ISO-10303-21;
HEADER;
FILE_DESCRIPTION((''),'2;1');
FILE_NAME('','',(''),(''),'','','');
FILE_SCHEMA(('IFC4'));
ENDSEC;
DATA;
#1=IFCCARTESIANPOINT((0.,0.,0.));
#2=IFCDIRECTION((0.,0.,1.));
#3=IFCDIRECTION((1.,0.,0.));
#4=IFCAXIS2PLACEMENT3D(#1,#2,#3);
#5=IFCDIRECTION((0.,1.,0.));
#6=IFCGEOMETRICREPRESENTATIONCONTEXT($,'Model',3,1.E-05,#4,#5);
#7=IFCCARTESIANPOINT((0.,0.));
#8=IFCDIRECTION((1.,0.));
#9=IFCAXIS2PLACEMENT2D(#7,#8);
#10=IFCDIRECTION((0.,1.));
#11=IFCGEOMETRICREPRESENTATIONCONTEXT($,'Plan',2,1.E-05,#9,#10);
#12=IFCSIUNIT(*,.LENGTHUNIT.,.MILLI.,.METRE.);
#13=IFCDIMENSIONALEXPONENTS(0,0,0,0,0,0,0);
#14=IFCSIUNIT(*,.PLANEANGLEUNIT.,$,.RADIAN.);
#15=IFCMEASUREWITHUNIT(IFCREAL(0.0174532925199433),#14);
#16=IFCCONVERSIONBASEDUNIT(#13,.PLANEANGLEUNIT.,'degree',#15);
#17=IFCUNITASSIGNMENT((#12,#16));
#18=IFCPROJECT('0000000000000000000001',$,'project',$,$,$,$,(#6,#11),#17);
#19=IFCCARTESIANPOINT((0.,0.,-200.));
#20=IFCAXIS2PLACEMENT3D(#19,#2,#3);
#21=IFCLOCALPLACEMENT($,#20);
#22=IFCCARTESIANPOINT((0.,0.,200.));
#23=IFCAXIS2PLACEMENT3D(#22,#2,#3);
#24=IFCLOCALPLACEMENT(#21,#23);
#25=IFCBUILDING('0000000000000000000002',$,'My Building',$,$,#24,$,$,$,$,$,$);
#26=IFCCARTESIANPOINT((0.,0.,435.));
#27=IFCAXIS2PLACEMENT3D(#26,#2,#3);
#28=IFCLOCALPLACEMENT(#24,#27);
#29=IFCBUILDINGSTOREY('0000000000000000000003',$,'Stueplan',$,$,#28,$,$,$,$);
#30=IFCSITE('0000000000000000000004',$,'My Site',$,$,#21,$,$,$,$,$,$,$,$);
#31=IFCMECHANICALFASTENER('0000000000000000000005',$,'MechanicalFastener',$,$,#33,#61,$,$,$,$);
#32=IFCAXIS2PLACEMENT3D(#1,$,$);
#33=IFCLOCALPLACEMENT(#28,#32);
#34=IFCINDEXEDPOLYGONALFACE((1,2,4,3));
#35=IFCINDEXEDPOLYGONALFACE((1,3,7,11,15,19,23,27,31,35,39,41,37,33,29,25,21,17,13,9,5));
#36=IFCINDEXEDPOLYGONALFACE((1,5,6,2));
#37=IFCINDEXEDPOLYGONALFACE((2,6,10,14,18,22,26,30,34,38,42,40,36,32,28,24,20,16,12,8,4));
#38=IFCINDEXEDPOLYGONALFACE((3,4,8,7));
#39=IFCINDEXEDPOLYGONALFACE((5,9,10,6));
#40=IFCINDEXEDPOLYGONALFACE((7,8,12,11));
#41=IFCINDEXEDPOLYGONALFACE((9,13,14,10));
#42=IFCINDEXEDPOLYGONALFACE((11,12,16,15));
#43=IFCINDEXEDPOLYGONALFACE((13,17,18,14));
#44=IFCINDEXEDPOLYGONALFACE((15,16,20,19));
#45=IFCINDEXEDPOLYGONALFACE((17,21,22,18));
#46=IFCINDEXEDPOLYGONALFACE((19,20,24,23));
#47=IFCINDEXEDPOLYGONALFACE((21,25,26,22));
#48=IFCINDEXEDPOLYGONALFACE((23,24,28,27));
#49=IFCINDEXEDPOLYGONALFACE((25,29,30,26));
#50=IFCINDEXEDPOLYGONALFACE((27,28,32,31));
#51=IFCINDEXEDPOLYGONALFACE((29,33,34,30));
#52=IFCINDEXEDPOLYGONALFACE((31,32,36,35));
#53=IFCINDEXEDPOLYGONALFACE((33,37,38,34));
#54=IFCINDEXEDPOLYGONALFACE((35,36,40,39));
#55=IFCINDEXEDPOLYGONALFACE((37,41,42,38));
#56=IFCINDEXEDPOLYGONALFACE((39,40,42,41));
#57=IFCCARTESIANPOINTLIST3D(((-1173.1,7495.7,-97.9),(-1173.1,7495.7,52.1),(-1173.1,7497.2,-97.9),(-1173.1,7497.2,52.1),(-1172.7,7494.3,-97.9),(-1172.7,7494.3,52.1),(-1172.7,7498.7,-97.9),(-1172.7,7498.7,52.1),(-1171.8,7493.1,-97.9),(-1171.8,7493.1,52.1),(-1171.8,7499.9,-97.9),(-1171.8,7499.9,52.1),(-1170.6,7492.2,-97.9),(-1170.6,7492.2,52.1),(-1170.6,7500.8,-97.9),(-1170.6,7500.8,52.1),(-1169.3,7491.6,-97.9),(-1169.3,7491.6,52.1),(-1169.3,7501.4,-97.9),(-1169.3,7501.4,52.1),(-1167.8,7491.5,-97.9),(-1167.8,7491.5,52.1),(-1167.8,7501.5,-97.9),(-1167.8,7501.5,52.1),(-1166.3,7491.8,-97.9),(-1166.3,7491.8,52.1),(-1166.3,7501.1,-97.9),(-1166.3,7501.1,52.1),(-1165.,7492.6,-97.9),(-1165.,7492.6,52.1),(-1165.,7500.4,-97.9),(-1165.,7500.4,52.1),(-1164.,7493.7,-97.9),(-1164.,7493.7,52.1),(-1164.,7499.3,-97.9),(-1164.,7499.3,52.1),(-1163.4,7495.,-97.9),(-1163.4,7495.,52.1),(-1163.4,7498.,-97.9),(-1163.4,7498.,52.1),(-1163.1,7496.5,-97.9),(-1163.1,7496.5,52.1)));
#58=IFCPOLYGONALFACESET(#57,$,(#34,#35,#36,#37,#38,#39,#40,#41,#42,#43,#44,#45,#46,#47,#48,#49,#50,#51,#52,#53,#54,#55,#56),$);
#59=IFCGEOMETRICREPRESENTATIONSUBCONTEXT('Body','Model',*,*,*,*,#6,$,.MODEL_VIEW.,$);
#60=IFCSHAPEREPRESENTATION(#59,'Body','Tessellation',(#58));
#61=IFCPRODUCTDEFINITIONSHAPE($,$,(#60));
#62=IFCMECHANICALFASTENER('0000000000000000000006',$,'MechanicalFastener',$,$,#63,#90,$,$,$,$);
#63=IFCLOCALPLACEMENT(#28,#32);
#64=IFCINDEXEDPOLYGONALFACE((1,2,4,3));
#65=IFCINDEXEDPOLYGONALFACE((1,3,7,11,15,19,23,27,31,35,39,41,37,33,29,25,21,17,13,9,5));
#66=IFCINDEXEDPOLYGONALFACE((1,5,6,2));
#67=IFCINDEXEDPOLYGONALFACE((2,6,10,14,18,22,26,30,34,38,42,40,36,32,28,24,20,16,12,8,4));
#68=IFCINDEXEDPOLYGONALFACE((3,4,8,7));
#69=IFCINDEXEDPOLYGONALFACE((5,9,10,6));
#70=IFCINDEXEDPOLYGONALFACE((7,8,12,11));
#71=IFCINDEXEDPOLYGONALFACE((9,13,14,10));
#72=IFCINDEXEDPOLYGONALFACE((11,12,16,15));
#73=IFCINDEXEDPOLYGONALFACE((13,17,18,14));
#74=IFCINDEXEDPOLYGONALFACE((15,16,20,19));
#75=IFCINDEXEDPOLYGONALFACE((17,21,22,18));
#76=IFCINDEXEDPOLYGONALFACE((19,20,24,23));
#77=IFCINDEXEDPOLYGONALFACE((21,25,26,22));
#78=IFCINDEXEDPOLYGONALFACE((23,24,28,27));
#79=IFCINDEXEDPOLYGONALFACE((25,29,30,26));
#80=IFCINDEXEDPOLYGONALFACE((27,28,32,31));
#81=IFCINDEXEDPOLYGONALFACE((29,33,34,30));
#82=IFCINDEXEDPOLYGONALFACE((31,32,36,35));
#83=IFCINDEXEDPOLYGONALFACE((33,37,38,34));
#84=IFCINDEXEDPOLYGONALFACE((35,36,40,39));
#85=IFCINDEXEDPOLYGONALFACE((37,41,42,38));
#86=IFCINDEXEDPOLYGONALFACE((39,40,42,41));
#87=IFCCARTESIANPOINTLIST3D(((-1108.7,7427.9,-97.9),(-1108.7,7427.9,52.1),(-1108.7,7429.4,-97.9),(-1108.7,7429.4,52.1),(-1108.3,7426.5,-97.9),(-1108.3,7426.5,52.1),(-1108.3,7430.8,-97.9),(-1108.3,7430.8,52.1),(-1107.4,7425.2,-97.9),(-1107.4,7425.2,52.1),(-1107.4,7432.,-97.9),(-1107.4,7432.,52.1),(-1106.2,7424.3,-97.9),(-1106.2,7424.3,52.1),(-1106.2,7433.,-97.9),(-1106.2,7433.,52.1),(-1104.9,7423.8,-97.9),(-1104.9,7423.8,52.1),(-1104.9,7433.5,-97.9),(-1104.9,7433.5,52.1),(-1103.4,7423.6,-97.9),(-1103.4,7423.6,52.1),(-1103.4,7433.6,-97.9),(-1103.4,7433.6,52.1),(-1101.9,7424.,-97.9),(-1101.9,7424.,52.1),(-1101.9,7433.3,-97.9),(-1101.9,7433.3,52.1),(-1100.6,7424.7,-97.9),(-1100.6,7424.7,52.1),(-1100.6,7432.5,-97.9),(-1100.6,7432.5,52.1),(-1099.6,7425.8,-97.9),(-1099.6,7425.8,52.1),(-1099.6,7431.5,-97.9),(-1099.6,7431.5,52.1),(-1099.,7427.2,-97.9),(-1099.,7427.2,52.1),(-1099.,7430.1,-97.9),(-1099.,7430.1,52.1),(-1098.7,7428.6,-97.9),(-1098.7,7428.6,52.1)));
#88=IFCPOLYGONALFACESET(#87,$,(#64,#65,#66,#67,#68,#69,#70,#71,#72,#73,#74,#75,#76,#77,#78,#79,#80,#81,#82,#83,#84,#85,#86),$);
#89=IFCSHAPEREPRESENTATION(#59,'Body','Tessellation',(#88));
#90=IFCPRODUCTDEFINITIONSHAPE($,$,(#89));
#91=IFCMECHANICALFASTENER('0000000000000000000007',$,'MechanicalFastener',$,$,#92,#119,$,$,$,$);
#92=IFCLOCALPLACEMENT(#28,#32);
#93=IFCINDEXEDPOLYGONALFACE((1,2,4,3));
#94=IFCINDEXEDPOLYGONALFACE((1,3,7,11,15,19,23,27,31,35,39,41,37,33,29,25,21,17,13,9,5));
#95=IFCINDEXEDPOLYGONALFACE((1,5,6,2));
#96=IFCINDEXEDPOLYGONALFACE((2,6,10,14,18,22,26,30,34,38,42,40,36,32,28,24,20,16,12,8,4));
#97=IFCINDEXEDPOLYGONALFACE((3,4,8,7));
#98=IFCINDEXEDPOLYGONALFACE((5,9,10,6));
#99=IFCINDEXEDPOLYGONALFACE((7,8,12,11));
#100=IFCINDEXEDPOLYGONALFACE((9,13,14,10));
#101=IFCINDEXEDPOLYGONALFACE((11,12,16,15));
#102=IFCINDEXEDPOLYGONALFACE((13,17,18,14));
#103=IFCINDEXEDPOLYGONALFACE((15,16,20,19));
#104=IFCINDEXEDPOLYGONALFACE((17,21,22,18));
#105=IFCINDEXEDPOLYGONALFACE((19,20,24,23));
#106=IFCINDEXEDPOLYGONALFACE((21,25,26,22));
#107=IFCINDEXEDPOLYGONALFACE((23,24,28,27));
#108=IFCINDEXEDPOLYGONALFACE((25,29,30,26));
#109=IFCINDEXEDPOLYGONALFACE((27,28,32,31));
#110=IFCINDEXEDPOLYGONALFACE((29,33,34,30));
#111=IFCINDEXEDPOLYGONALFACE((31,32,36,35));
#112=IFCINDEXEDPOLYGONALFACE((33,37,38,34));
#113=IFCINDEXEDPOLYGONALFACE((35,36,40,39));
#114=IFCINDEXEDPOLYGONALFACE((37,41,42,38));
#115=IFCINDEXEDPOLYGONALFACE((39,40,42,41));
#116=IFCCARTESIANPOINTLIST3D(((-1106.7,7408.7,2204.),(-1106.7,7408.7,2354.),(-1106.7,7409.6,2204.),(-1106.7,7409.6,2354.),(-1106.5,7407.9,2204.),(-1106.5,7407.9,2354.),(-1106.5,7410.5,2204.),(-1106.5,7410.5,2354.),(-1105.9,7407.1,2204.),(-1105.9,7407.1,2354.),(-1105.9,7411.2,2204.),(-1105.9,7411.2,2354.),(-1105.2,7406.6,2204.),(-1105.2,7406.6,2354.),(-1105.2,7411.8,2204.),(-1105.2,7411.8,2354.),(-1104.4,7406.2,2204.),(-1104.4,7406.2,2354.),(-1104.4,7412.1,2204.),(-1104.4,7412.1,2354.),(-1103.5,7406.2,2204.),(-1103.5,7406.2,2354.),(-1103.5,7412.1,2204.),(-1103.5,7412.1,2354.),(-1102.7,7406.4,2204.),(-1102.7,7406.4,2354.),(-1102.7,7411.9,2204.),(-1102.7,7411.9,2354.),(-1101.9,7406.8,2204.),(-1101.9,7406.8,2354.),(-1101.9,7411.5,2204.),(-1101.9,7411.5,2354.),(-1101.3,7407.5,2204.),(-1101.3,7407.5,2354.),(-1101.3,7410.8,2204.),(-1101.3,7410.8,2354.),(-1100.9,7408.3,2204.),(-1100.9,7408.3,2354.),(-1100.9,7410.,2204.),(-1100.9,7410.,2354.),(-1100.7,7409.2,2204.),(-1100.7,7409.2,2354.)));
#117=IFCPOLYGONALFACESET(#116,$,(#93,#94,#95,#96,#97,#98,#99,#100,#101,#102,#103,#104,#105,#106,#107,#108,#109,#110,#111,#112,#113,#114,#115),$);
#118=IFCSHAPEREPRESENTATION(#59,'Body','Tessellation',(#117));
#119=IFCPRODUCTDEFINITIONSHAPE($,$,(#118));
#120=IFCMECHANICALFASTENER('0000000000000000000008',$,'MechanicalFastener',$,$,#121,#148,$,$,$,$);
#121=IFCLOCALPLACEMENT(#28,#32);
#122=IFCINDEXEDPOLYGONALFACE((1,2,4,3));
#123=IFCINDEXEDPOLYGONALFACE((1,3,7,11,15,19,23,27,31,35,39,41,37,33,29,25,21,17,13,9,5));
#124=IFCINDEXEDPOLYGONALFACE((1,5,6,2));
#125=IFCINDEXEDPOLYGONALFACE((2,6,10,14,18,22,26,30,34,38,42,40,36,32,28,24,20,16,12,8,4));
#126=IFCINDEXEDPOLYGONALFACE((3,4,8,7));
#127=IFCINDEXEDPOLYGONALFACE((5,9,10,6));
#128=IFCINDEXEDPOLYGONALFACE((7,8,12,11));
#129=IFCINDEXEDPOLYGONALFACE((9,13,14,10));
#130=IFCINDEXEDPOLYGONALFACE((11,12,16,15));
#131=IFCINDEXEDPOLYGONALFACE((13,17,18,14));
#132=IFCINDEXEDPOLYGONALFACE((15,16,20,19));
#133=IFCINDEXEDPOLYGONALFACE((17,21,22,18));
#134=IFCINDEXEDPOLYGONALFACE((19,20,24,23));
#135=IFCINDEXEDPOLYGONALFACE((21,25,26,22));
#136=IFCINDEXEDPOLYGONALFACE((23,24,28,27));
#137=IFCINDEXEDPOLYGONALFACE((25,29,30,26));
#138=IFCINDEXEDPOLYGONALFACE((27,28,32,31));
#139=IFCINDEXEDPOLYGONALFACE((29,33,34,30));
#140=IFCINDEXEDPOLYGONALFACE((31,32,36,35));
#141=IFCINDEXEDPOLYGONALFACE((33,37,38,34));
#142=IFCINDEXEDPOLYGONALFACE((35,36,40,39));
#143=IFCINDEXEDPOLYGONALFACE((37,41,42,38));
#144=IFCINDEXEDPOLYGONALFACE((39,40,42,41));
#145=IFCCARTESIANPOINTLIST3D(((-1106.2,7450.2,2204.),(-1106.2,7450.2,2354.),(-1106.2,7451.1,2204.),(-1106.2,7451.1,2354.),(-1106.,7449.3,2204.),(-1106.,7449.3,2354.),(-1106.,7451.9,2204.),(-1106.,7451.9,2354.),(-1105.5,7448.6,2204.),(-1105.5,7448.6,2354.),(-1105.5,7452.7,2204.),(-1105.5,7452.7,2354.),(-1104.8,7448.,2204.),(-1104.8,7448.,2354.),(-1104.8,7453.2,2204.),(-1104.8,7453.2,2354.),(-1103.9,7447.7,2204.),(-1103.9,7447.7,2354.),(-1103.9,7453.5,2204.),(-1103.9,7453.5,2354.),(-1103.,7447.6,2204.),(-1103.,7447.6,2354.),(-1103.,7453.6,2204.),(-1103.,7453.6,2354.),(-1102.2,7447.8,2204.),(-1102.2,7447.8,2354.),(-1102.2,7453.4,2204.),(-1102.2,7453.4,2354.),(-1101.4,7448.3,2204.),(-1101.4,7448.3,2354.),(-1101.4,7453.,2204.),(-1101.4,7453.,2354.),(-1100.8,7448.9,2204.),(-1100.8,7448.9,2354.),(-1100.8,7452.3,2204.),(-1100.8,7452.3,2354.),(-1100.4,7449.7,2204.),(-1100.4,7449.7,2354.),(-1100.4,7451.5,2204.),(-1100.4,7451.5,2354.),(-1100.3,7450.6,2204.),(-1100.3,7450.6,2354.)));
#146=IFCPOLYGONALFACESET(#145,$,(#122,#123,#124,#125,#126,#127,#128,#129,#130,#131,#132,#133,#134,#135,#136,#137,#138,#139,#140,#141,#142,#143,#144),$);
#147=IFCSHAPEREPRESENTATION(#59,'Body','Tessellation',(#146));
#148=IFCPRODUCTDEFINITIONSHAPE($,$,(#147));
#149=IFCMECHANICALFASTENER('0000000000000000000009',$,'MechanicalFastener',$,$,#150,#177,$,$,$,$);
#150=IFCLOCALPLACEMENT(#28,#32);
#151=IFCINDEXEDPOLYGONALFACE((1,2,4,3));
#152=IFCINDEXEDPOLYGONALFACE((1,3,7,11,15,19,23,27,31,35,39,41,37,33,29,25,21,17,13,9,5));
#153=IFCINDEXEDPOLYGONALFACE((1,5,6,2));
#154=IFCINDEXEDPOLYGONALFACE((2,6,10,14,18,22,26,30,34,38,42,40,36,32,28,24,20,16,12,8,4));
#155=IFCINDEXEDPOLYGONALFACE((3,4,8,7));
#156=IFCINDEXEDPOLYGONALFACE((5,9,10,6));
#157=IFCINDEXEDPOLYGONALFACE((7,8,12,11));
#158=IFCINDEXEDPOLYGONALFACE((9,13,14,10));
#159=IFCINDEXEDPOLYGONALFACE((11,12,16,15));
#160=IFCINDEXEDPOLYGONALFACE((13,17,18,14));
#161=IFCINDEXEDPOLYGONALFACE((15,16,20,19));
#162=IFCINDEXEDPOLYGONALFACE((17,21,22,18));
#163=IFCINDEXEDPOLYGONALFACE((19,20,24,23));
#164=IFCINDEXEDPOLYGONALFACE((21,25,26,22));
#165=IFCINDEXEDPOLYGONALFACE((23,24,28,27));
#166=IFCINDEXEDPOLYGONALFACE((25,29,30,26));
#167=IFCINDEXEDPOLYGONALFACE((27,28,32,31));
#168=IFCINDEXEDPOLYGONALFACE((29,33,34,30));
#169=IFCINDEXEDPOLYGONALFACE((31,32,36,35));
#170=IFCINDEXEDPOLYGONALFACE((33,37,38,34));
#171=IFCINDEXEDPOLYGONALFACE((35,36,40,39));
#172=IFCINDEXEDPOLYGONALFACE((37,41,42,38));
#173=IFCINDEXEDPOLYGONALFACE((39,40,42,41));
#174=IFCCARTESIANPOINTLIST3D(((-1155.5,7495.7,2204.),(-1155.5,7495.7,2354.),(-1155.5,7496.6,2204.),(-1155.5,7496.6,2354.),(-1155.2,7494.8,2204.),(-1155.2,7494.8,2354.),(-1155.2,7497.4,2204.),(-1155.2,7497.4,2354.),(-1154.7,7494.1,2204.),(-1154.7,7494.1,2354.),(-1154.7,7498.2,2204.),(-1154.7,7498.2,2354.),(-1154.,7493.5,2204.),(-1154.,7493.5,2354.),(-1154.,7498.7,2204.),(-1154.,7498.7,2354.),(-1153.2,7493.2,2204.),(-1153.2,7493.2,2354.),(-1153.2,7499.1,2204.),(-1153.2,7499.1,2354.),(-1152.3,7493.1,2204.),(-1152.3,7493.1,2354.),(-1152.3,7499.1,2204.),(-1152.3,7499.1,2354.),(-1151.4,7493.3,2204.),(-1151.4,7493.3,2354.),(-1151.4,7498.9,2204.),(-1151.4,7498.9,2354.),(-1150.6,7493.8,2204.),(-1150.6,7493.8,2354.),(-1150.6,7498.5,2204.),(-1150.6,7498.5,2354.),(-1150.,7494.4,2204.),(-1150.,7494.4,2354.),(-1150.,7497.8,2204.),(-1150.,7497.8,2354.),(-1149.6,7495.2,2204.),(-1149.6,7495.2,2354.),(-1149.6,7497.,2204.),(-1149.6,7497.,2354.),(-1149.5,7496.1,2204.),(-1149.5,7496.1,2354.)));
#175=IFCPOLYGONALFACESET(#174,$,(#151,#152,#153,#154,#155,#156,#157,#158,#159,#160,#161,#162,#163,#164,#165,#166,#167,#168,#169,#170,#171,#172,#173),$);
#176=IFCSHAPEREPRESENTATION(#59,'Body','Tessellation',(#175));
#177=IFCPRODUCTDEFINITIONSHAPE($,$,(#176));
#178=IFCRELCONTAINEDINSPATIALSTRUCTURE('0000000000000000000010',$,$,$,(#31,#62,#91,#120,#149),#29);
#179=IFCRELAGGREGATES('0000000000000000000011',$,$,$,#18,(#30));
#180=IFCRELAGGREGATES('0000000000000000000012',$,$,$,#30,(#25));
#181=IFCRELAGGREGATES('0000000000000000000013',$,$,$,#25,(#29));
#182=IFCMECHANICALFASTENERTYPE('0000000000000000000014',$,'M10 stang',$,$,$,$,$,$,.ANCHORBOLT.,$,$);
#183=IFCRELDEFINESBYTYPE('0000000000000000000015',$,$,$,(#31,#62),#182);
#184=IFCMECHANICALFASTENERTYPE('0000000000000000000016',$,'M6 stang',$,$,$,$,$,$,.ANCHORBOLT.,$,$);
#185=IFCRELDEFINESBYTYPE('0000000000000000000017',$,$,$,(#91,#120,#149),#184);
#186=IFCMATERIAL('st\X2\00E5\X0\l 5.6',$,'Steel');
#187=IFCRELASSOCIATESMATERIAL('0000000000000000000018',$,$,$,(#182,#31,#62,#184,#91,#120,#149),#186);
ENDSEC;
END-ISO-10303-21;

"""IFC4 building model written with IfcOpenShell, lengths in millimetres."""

from ifc_helpers import new_model, entity, si_unit, converted_unit, direction, frame, origin_with_axes, origin_2d_with_axis, place, context, subcontext, project, spatial, circle, extrude, material, material_profile, profile_set, profile_usage, type_object, element, save


model = new_model("IFC4")

# Units and contexts
model_context = context("Model", 3, precision=1e-05, world=origin_with_axes(), true_north=direction((0.0, 1.0, 0.0)))
plan_context = context("Plan", 2, precision=1e-05, world=origin_2d_with_axis(), true_north=direction((0.0, 1.0)))
body_context_1 = subcontext(model_context, "Body", "Model", "MODEL_VIEW")
ifc_project = project(units=[si_unit("LENGTHUNIT", "METRE", prefix="MILLI"), converted_unit("PLANEANGLEUNIT", "degree", entity("IfcReal", 0.0174532925199433), si_unit("PLANEANGLEUNIT", "RADIAN"), dimensions=[0, 0, 0, 0, 0, 0, 0])], contexts=[model_context, plan_context])

# Site, building, storey
site_placement = place(None, frame((0.0, 0.0, -200.0), z_axis=(0.0, 0.0, 1.0), x_axis=(1.0, 0.0, 0.0)))
site = spatial("IfcSite", under=ifc_project, at=site_placement, Name="My Site")
building_placement = place(site_placement, frame((0.0, 0.0, 200.0), z_axis=(0.0, 0.0, 1.0), x_axis=(1.0, 0.0, 0.0)))
building = spatial("IfcBuilding", under=site, at=building_placement, Name="My Building")
storey_placement = place(building_placement, frame((0.0, 0.0, 435.0), z_axis=(0.0, 0.0, 1.0), x_axis=(1.0, 0.0, 0.0)))
storey = spatial("IfcBuildingStorey", under=building, at=storey_placement, Name="Stueplan")

# Mechanical fasteners
ifc_material_1 = material(Name="stål 5.6", Category="Steel")
ifc_material_profile_1 = material_profile(ifc_material_1, circle(Radius=5.0, kind="CURVE"))
ifc_profile_set_1 = profile_set([ifc_material_profile_1], Name="steel")
ifc_profile_usage_1 = profile_usage(ifc_profile_set_1, cardinal=5)
mechanical_fastener_type_1 = type_object("IfcMechanicalFastenerType", Name="M10 stang", PredefinedType="ANCHORBOLT", material=ifc_profile_set_1)
mechanical_fastener_1_placement = place(storey_placement, frame((-1168.1, 7496.5, -97.9), z_axis=(0.0, 0.0, 1.0), x_axis=(1.0, 0.0, 0.0)))
element("IfcMechanicalFastener", 1, at=mechanical_fastener_1_placement, inside=storey, type_object=mechanical_fastener_type_1, material=ifc_profile_usage_1, Name="MechanicalFastener", context=body_context_1, shape_type="SweptSolid", body=[
    extrude(circle(Radius=5.0, kind="CURVE"), origin_with_axes(), (0.0, 0.0, 1.0), 150.0),
])
ifc_profile_usage_2 = profile_usage(ifc_profile_set_1, cardinal=5)
mechanical_fastener_2_placement = place(storey_placement, frame((-1103.7, 7428.6, -97.9), z_axis=(0.0, 0.0, 1.0), x_axis=(1.0, 0.0, 0.0)))
element("IfcMechanicalFastener", 2, at=mechanical_fastener_2_placement, inside=storey, type_object=mechanical_fastener_type_1, material=ifc_profile_usage_2, Name="MechanicalFastener", context=body_context_1, shape_type="SweptSolid", body=[
    extrude(circle(Radius=5.0, kind="CURVE"), origin_with_axes(), (0.0, 0.0, 1.0), 150.0),
])
ifc_material_profile_2 = material_profile(ifc_material_1, circle(Radius=3.0))
ifc_profile_set_2 = profile_set([ifc_material_profile_2], Name="steel")
ifc_profile_usage_3 = profile_usage(ifc_profile_set_2)
mechanical_fastener_type_2 = type_object("IfcMechanicalFastenerType", Name="M6 stang", PredefinedType="ANCHORBOLT", material=ifc_profile_set_2)
mechanical_fastener_3_placement = place(storey_placement, frame((-1103.7, 7409.2, 2204.0), z_axis=(0.0, 0.0, 1.0), x_axis=(1.0, 0.0, 0.0)))
element("IfcMechanicalFastener", 3, at=mechanical_fastener_3_placement, inside=storey, type_object=mechanical_fastener_type_2, material=ifc_profile_usage_3, Name="MechanicalFastener", context=body_context_1, shape_type="SweptSolid", body=[
    extrude(circle(Radius=3.0), origin_with_axes(), (0.0, 0.0, 1.0), 150.0),
])
ifc_profile_usage_4 = profile_usage(ifc_profile_set_2)
mechanical_fastener_4_placement = place(storey_placement, frame((-1103.3, 7450.6, 2204.0), z_axis=(0.0, 0.0, 1.0), x_axis=(1.0, 0.0, 0.0)))
element("IfcMechanicalFastener", 4, at=mechanical_fastener_4_placement, inside=storey, type_object=mechanical_fastener_type_2, material=ifc_profile_usage_4, Name="MechanicalFastener", context=body_context_1, shape_type="SweptSolid", body=[
    extrude(circle(Radius=3.0), origin_with_axes(), (0.0, 0.0, 1.0), 150.0),
])
ifc_profile_usage_5 = profile_usage(ifc_profile_set_2)
mechanical_fastener_5_placement = place(storey_placement, frame((-1152.5, 7496.1, 2204.0), z_axis=(0.0, 0.0, 1.0), x_axis=(1.0, 0.0, 0.0)))
element("IfcMechanicalFastener", 5, at=mechanical_fastener_5_placement, inside=storey, type_object=mechanical_fastener_type_2, material=ifc_profile_usage_5, Name="MechanicalFastener", context=body_context_1, shape_type="SweptSolid", body=[
    extrude(circle(Radius=3.0), origin_with_axes(), (0.0, 0.0, 1.0), 150.0),
])

save(model, "model.ifc")
